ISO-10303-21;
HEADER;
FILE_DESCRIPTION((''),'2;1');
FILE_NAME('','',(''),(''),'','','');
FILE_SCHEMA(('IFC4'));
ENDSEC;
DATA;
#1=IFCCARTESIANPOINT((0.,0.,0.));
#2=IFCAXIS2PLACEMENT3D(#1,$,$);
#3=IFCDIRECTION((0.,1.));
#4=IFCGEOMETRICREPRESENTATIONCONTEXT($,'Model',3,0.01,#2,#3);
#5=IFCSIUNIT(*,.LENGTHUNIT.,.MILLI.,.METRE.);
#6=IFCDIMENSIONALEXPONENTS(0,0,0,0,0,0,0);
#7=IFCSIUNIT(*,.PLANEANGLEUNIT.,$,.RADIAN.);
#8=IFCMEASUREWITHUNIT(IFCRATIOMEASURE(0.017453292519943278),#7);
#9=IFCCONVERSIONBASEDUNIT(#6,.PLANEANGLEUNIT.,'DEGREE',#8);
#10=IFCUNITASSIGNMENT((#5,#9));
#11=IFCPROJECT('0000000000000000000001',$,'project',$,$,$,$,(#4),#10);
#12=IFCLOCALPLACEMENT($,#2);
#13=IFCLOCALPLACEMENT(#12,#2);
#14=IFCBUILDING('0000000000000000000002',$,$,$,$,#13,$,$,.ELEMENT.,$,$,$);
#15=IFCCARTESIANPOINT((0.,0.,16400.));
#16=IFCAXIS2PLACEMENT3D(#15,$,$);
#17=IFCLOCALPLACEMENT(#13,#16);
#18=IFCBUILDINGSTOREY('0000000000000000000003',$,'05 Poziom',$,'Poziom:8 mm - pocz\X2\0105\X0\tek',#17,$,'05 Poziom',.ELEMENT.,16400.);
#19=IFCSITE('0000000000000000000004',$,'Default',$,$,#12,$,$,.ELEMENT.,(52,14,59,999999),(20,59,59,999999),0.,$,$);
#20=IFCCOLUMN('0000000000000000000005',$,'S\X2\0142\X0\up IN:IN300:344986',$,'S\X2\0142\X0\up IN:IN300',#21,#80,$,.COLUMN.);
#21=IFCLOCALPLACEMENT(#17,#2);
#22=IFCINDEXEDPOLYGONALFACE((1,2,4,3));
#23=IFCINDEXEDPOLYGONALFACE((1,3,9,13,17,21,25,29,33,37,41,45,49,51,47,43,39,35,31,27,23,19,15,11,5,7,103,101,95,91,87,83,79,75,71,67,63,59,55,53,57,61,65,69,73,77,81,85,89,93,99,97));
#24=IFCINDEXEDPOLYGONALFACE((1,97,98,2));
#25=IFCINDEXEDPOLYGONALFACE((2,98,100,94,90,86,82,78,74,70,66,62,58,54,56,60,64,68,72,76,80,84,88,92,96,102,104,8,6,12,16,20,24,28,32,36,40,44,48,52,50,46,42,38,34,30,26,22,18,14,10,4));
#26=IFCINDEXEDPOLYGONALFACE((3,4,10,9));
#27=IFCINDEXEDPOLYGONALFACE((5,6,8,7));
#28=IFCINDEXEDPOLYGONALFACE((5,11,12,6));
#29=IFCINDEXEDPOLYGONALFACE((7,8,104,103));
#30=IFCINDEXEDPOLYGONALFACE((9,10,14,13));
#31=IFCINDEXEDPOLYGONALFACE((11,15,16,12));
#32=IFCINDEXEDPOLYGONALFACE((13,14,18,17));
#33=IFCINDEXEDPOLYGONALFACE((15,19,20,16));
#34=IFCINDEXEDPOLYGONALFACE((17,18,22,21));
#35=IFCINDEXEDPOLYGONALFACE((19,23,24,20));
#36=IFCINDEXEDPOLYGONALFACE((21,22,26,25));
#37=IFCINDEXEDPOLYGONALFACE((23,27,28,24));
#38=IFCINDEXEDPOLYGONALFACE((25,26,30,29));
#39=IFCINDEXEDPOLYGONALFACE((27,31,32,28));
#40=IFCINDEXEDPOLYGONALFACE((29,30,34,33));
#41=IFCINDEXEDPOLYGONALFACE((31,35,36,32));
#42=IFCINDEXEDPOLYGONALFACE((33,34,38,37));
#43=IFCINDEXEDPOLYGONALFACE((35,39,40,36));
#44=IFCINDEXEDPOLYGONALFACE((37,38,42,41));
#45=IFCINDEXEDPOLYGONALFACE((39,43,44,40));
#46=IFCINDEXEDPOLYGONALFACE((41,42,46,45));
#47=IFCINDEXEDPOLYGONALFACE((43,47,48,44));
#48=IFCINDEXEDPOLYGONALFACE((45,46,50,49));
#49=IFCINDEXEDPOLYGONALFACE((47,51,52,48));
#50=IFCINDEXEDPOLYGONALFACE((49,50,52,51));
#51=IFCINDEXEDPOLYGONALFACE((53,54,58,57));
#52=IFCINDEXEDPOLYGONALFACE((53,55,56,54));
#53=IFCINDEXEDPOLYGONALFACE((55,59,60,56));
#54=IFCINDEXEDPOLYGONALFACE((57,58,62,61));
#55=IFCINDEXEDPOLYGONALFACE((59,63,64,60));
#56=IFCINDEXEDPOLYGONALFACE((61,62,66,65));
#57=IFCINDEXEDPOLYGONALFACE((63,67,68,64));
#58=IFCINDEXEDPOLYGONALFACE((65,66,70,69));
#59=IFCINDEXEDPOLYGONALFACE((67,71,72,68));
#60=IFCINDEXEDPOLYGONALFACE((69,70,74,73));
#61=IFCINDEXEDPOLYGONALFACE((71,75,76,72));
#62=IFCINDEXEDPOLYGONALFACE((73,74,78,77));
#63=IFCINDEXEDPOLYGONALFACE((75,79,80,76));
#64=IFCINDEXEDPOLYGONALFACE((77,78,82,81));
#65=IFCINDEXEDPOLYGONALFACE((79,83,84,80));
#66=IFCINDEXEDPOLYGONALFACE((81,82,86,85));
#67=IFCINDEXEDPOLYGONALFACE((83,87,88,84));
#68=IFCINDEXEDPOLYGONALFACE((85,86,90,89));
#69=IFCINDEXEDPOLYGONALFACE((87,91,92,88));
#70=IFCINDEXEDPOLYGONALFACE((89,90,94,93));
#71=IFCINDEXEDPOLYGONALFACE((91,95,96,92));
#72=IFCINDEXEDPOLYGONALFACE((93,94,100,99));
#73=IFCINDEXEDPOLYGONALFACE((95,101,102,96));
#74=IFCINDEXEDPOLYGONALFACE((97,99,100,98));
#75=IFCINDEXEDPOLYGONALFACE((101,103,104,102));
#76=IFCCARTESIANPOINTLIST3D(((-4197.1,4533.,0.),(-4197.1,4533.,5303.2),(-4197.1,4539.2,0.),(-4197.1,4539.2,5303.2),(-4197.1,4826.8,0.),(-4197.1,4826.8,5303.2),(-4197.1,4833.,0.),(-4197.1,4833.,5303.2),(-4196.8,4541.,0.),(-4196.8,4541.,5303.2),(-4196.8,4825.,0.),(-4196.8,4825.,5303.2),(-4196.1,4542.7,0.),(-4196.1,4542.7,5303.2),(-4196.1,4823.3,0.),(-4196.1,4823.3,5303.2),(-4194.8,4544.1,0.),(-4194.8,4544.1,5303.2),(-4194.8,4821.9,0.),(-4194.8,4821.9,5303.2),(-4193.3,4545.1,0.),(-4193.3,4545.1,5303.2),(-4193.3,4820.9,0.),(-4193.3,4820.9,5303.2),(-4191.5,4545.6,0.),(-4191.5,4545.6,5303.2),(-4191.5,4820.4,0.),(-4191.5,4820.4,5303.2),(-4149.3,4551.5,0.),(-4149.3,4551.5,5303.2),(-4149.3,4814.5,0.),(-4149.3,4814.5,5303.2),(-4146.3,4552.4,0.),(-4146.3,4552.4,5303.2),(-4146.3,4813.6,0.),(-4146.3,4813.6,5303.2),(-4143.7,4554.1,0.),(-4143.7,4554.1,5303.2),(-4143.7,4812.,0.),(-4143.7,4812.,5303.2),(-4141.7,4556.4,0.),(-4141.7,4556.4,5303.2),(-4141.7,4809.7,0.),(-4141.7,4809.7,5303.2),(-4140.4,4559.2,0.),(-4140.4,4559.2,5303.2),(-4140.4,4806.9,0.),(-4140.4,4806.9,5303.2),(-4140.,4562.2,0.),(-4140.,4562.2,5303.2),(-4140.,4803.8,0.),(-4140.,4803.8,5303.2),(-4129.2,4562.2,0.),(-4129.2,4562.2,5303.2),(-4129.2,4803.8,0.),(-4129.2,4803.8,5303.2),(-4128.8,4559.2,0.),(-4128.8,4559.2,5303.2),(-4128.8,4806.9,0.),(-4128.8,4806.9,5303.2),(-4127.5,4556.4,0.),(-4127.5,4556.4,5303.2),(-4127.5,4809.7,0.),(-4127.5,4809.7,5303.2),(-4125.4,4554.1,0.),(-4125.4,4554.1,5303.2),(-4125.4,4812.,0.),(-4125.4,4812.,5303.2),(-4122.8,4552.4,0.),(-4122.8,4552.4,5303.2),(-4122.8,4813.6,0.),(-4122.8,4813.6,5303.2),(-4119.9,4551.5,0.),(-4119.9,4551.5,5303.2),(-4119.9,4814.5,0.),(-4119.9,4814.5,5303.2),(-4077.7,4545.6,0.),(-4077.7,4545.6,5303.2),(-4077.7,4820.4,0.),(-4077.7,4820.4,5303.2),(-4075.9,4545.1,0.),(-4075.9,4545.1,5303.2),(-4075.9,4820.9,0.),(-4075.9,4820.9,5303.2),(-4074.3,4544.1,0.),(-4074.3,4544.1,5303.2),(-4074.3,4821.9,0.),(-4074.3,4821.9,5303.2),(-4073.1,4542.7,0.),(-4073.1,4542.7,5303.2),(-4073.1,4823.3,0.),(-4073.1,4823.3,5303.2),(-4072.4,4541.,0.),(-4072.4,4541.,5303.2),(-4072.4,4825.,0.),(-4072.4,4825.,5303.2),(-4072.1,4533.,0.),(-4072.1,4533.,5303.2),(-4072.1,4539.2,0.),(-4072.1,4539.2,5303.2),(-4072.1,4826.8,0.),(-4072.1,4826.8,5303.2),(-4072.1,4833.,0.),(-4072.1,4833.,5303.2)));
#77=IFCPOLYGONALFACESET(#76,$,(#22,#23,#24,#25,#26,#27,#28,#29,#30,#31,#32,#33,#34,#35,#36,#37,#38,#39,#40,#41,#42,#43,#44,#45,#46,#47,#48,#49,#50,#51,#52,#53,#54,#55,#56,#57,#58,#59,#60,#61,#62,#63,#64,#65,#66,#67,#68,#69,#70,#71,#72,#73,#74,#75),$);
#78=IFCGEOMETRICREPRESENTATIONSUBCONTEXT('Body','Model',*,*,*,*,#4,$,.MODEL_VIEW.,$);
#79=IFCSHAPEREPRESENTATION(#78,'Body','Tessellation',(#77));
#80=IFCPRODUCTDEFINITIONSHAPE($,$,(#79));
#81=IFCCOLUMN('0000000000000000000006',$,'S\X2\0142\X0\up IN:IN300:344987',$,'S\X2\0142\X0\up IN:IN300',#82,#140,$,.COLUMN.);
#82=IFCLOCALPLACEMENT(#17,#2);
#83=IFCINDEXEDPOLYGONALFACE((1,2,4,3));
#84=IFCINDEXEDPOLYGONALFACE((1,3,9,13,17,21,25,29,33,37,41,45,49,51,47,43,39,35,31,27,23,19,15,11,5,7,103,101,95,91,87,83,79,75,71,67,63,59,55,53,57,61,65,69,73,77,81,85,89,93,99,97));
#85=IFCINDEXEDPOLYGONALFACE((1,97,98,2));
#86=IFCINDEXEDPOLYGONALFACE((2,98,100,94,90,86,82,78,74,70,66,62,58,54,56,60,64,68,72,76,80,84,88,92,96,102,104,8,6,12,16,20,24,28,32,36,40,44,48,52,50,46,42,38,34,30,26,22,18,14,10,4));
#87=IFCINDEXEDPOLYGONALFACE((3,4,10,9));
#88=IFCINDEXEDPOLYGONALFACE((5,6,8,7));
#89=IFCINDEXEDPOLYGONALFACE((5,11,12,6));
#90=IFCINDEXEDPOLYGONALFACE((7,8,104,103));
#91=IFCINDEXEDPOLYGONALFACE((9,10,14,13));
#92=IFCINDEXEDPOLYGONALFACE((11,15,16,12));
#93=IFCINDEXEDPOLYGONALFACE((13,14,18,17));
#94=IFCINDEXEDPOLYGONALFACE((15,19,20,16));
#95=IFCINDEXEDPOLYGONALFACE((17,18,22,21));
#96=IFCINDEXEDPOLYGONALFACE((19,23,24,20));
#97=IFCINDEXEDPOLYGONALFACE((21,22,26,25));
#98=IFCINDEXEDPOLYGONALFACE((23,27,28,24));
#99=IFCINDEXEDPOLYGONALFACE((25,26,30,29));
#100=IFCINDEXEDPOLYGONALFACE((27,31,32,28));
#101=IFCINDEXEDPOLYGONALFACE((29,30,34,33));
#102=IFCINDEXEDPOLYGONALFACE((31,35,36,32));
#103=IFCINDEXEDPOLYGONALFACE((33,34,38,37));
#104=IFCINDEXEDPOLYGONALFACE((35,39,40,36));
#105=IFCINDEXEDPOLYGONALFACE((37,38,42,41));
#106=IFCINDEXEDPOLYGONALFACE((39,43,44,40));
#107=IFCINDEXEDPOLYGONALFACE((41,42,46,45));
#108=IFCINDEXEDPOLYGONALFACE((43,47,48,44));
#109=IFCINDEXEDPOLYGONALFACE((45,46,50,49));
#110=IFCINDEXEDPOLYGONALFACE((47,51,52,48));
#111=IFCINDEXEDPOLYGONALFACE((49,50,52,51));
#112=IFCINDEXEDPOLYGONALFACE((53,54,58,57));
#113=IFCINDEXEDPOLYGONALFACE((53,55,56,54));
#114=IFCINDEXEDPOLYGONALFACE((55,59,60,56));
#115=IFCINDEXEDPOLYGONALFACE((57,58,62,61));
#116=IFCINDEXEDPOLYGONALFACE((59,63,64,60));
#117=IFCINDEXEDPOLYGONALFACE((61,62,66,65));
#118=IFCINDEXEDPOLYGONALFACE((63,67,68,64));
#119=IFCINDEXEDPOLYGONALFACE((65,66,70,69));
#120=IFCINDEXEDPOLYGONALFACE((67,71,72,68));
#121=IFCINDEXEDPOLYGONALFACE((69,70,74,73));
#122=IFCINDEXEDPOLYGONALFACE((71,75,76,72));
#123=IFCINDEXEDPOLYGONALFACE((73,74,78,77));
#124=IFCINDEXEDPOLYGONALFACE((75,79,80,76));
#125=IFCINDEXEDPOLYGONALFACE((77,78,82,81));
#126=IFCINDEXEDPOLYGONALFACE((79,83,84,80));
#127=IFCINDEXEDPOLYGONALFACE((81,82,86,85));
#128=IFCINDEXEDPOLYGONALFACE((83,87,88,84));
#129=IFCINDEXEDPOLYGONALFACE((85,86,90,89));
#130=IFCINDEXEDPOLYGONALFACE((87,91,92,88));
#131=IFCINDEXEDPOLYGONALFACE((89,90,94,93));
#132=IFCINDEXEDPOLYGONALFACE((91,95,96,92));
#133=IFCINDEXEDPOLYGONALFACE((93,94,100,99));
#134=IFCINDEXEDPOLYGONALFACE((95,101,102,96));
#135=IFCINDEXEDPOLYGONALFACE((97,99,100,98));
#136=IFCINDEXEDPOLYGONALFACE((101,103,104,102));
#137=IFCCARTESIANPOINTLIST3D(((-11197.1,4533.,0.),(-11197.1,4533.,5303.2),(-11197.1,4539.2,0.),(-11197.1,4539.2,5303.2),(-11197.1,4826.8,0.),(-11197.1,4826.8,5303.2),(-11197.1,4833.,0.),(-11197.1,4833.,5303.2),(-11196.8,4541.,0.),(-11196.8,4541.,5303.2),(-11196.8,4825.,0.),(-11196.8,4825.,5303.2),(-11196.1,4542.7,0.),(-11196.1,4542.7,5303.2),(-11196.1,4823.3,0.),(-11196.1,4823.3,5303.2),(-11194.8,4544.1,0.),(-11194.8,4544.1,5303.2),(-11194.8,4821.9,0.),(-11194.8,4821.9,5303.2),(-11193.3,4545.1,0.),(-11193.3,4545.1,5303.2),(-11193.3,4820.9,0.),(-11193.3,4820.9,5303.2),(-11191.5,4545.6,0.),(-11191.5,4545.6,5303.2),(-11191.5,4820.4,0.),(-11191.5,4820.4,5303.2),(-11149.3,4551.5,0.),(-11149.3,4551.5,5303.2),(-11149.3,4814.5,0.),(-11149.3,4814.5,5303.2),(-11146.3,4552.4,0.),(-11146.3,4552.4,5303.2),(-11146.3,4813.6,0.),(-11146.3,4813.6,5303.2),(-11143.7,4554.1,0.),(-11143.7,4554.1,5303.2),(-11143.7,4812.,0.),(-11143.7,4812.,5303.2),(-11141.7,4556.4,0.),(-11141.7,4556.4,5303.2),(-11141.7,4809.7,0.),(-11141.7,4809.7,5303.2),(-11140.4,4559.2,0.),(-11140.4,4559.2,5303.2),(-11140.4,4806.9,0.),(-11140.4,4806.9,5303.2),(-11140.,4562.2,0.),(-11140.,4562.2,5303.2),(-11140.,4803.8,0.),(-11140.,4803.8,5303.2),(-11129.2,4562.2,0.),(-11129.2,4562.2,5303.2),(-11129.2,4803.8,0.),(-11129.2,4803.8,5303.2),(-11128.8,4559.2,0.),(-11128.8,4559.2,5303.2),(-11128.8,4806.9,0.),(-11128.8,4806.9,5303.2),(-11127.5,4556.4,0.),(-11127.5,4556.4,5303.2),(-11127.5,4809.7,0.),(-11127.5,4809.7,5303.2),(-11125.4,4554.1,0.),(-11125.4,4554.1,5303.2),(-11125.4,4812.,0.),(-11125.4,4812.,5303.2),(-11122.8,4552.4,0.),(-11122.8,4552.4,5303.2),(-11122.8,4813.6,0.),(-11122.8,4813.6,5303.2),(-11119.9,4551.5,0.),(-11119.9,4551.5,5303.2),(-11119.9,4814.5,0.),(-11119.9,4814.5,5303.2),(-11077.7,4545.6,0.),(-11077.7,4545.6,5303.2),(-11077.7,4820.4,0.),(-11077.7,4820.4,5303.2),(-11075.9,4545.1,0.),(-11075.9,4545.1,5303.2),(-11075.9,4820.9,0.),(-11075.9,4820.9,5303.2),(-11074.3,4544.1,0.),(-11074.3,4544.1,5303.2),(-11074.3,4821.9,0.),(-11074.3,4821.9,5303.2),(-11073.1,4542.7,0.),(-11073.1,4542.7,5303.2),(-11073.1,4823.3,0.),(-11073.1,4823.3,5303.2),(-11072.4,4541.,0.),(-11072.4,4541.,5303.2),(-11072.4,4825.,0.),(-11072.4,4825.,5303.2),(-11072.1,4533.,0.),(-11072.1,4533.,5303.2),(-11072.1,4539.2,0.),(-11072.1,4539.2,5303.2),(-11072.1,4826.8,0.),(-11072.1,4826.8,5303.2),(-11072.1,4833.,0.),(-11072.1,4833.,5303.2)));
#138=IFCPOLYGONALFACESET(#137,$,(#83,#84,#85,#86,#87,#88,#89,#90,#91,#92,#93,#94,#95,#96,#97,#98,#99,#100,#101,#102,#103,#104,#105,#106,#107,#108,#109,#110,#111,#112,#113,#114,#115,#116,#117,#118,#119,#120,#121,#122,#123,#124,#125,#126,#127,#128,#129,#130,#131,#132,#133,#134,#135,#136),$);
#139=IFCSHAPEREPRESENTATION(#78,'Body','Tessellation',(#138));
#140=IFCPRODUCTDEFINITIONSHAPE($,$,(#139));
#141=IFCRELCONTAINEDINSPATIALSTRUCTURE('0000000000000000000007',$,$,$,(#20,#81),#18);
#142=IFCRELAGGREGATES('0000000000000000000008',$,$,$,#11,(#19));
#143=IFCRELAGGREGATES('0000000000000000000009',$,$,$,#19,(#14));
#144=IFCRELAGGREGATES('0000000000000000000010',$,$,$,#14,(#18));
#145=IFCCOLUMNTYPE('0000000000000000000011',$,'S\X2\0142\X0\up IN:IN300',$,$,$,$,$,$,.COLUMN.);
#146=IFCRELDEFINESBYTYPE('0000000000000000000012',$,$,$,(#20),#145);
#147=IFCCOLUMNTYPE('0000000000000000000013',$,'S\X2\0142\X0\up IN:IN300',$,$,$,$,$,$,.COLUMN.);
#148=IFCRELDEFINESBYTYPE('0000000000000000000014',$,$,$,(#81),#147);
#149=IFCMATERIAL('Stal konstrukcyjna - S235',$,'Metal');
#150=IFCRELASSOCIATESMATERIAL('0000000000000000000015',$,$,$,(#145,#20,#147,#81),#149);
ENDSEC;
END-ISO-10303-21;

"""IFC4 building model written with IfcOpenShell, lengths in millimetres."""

from ifc_helpers import new_model, entity, si_unit, converted_unit, direction, frame, origin, place, context, subcontext, project, spatial, line, arc, indexed_curve, outline, extrude, source, transform, mapped, material, type_object, type_shapes, element, save


model = new_model("IFC4")

# Units and contexts
model_context = context("Model", 3, precision=0.01, world=origin(), true_north=direction((0.0, 1.0)))
body_context = subcontext(model_context, "Body", "Model", "MODEL_VIEW")
ifc_project = project(units=[si_unit("LENGTHUNIT", "METRE", prefix="MILLI"), converted_unit("PLANEANGLEUNIT", "DEGREE", entity("IfcRatioMeasure", 0.017453292519943278), si_unit("PLANEANGLEUNIT", "RADIAN"), dimensions=[0, 0, 0, 0, 0, 0, 0])], contexts=[model_context])

# Site, building, storey
site_placement = place(None, origin())
site = spatial("IfcSite", under=ifc_project, at=site_placement, Name="Default", CompositionType="ELEMENT", RefLatitude=(52, 14, 59, 999999), RefLongitude=(20, 59, 59, 999999), RefElevation=0.0)
building_placement = place(site_placement, origin())
building = spatial("IfcBuilding", under=site, at=building_placement, CompositionType="ELEMENT")
storey_placement = place(building_placement, frame((0.0, 0.0, 16400.0)))
storey = spatial("IfcBuildingStorey", under=building, at=storey_placement, Name="05 Poziom", ObjectType="Poziom:8 mm - początek", LongName="05 Poziom", CompositionType="ELEMENT", Elevation=16400.0)

# Columns
ifc_material = material(Name="Stal konstrukcyjna - S235", Category="Metal")
column_type_1 = type_object("IfcColumnType", Name="Słup IN:IN300", PredefinedType="COLUMN", material=ifc_material)
shared_shape_1 = source(origin(), body_context, "Body", "SweptSolid", [
    extrude(outline(indexed_curve([(143.8, -62.5), (150.0, -62.5), (150.0, 62.5), (143.8, 62.5), (139.6, 60.9), (137.4, 56.9), (131.5, 14.7), (127.9, 8.1), (120.8, 5.4), (-120.8, 5.4), (-127.9, 8.1), (-131.5, 14.7), (-137.4, 56.9), (-139.6, 60.9), (-143.8, 62.5), (-150.0, 62.5), (-150.0, -62.5), (-143.8, -62.5), (-139.6, -60.9), (-137.4, -56.9), (-131.5, -14.7), (-127.9, -8.1), (-120.8, -5.4), (120.8, -5.4), (127.9, -8.1), (131.5, -14.7), (137.4, -56.9), (139.6, -60.9)], segments=[line(1, 2, 3, 4), arc(4, 5, 6), line(6, 7), arc(7, 8, 9), line(9, 10), arc(10, 11, 12), line(12, 13), arc(13, 14, 15), line(15, 16, 17, 18), arc(18, 19, 20), line(20, 21), arc(21, 22, 23), line(23, 24), arc(24, 25, 26), line(26, 27), arc(27, 28, 1)], self_intersect=False)), frame((-4134.6, 4683.0, 16400.0), z_axis=(0.0, 0.0, 1.0), x_axis=(0.0, -1.0, 0.0)), (0.0, 0.0, 1.0), 5303.2),
])
type_shapes(column_type_1, [shared_shape_1])
column_1_placement = place(storey_placement, frame((0.0, 0.0, -16400.0)))
element("IfcColumn", 1, at=column_1_placement, inside=storey, type_object=column_type_1, material=ifc_material, Name="Słup IN:IN300:344986", ObjectType="Słup IN:IN300", PredefinedType="COLUMN", context=body_context, shape_type="MappedRepresentation", body=[
    mapped(shared_shape_1, transform((0.0, 0.0, 0.0), scale=1.0)),
])
column_type_2 = type_object("IfcColumnType", Name="Słup IN:IN300", PredefinedType="COLUMN", material=ifc_material)
shared_shape_2 = source(origin(), body_context, "Body", "SweptSolid", [
    extrude(outline(indexed_curve([(143.8, -62.5), (150.0, -62.5), (150.0, 62.5), (143.8, 62.5), (139.6, 60.9), (137.4, 56.9), (131.5, 14.7), (127.9, 8.1), (120.8, 5.4), (-120.8, 5.4), (-127.9, 8.1), (-131.5, 14.7), (-137.4, 56.9), (-139.6, 60.9), (-143.8, 62.5), (-150.0, 62.5), (-150.0, -62.5), (-143.8, -62.5), (-139.6, -60.9), (-137.4, -56.9), (-131.5, -14.7), (-127.9, -8.1), (-120.8, -5.4), (120.8, -5.4), (127.9, -8.1), (131.5, -14.7), (137.4, -56.9), (139.6, -60.9)], segments=[line(1, 2, 3, 4), arc(4, 5, 6), line(6, 7), arc(7, 8, 9), line(9, 10), arc(10, 11, 12), line(12, 13), arc(13, 14, 15), line(15, 16, 17, 18), arc(18, 19, 20), line(20, 21), arc(21, 22, 23), line(23, 24), arc(24, 25, 26), line(26, 27), arc(27, 28, 1)], self_intersect=False)), frame((-11134.6, 4683.0, 16400.0), z_axis=(0.0, 0.0, 1.0), x_axis=(0.0, -1.0, 0.0)), (0.0, 0.0, 1.0), 5303.2),
])
type_shapes(column_type_2, [shared_shape_2])
column_2_placement = place(storey_placement, frame((0.0, 0.0, -16400.0)))
element("IfcColumn", 2, at=column_2_placement, inside=storey, type_object=column_type_2, material=ifc_material, Name="Słup IN:IN300:344987", ObjectType="Słup IN:IN300", PredefinedType="COLUMN", context=body_context, shape_type="MappedRepresentation", body=[
    mapped(shared_shape_2, transform((0.0, 0.0, 0.0), scale=1.0)),
])

save(model, "model.ifc")
